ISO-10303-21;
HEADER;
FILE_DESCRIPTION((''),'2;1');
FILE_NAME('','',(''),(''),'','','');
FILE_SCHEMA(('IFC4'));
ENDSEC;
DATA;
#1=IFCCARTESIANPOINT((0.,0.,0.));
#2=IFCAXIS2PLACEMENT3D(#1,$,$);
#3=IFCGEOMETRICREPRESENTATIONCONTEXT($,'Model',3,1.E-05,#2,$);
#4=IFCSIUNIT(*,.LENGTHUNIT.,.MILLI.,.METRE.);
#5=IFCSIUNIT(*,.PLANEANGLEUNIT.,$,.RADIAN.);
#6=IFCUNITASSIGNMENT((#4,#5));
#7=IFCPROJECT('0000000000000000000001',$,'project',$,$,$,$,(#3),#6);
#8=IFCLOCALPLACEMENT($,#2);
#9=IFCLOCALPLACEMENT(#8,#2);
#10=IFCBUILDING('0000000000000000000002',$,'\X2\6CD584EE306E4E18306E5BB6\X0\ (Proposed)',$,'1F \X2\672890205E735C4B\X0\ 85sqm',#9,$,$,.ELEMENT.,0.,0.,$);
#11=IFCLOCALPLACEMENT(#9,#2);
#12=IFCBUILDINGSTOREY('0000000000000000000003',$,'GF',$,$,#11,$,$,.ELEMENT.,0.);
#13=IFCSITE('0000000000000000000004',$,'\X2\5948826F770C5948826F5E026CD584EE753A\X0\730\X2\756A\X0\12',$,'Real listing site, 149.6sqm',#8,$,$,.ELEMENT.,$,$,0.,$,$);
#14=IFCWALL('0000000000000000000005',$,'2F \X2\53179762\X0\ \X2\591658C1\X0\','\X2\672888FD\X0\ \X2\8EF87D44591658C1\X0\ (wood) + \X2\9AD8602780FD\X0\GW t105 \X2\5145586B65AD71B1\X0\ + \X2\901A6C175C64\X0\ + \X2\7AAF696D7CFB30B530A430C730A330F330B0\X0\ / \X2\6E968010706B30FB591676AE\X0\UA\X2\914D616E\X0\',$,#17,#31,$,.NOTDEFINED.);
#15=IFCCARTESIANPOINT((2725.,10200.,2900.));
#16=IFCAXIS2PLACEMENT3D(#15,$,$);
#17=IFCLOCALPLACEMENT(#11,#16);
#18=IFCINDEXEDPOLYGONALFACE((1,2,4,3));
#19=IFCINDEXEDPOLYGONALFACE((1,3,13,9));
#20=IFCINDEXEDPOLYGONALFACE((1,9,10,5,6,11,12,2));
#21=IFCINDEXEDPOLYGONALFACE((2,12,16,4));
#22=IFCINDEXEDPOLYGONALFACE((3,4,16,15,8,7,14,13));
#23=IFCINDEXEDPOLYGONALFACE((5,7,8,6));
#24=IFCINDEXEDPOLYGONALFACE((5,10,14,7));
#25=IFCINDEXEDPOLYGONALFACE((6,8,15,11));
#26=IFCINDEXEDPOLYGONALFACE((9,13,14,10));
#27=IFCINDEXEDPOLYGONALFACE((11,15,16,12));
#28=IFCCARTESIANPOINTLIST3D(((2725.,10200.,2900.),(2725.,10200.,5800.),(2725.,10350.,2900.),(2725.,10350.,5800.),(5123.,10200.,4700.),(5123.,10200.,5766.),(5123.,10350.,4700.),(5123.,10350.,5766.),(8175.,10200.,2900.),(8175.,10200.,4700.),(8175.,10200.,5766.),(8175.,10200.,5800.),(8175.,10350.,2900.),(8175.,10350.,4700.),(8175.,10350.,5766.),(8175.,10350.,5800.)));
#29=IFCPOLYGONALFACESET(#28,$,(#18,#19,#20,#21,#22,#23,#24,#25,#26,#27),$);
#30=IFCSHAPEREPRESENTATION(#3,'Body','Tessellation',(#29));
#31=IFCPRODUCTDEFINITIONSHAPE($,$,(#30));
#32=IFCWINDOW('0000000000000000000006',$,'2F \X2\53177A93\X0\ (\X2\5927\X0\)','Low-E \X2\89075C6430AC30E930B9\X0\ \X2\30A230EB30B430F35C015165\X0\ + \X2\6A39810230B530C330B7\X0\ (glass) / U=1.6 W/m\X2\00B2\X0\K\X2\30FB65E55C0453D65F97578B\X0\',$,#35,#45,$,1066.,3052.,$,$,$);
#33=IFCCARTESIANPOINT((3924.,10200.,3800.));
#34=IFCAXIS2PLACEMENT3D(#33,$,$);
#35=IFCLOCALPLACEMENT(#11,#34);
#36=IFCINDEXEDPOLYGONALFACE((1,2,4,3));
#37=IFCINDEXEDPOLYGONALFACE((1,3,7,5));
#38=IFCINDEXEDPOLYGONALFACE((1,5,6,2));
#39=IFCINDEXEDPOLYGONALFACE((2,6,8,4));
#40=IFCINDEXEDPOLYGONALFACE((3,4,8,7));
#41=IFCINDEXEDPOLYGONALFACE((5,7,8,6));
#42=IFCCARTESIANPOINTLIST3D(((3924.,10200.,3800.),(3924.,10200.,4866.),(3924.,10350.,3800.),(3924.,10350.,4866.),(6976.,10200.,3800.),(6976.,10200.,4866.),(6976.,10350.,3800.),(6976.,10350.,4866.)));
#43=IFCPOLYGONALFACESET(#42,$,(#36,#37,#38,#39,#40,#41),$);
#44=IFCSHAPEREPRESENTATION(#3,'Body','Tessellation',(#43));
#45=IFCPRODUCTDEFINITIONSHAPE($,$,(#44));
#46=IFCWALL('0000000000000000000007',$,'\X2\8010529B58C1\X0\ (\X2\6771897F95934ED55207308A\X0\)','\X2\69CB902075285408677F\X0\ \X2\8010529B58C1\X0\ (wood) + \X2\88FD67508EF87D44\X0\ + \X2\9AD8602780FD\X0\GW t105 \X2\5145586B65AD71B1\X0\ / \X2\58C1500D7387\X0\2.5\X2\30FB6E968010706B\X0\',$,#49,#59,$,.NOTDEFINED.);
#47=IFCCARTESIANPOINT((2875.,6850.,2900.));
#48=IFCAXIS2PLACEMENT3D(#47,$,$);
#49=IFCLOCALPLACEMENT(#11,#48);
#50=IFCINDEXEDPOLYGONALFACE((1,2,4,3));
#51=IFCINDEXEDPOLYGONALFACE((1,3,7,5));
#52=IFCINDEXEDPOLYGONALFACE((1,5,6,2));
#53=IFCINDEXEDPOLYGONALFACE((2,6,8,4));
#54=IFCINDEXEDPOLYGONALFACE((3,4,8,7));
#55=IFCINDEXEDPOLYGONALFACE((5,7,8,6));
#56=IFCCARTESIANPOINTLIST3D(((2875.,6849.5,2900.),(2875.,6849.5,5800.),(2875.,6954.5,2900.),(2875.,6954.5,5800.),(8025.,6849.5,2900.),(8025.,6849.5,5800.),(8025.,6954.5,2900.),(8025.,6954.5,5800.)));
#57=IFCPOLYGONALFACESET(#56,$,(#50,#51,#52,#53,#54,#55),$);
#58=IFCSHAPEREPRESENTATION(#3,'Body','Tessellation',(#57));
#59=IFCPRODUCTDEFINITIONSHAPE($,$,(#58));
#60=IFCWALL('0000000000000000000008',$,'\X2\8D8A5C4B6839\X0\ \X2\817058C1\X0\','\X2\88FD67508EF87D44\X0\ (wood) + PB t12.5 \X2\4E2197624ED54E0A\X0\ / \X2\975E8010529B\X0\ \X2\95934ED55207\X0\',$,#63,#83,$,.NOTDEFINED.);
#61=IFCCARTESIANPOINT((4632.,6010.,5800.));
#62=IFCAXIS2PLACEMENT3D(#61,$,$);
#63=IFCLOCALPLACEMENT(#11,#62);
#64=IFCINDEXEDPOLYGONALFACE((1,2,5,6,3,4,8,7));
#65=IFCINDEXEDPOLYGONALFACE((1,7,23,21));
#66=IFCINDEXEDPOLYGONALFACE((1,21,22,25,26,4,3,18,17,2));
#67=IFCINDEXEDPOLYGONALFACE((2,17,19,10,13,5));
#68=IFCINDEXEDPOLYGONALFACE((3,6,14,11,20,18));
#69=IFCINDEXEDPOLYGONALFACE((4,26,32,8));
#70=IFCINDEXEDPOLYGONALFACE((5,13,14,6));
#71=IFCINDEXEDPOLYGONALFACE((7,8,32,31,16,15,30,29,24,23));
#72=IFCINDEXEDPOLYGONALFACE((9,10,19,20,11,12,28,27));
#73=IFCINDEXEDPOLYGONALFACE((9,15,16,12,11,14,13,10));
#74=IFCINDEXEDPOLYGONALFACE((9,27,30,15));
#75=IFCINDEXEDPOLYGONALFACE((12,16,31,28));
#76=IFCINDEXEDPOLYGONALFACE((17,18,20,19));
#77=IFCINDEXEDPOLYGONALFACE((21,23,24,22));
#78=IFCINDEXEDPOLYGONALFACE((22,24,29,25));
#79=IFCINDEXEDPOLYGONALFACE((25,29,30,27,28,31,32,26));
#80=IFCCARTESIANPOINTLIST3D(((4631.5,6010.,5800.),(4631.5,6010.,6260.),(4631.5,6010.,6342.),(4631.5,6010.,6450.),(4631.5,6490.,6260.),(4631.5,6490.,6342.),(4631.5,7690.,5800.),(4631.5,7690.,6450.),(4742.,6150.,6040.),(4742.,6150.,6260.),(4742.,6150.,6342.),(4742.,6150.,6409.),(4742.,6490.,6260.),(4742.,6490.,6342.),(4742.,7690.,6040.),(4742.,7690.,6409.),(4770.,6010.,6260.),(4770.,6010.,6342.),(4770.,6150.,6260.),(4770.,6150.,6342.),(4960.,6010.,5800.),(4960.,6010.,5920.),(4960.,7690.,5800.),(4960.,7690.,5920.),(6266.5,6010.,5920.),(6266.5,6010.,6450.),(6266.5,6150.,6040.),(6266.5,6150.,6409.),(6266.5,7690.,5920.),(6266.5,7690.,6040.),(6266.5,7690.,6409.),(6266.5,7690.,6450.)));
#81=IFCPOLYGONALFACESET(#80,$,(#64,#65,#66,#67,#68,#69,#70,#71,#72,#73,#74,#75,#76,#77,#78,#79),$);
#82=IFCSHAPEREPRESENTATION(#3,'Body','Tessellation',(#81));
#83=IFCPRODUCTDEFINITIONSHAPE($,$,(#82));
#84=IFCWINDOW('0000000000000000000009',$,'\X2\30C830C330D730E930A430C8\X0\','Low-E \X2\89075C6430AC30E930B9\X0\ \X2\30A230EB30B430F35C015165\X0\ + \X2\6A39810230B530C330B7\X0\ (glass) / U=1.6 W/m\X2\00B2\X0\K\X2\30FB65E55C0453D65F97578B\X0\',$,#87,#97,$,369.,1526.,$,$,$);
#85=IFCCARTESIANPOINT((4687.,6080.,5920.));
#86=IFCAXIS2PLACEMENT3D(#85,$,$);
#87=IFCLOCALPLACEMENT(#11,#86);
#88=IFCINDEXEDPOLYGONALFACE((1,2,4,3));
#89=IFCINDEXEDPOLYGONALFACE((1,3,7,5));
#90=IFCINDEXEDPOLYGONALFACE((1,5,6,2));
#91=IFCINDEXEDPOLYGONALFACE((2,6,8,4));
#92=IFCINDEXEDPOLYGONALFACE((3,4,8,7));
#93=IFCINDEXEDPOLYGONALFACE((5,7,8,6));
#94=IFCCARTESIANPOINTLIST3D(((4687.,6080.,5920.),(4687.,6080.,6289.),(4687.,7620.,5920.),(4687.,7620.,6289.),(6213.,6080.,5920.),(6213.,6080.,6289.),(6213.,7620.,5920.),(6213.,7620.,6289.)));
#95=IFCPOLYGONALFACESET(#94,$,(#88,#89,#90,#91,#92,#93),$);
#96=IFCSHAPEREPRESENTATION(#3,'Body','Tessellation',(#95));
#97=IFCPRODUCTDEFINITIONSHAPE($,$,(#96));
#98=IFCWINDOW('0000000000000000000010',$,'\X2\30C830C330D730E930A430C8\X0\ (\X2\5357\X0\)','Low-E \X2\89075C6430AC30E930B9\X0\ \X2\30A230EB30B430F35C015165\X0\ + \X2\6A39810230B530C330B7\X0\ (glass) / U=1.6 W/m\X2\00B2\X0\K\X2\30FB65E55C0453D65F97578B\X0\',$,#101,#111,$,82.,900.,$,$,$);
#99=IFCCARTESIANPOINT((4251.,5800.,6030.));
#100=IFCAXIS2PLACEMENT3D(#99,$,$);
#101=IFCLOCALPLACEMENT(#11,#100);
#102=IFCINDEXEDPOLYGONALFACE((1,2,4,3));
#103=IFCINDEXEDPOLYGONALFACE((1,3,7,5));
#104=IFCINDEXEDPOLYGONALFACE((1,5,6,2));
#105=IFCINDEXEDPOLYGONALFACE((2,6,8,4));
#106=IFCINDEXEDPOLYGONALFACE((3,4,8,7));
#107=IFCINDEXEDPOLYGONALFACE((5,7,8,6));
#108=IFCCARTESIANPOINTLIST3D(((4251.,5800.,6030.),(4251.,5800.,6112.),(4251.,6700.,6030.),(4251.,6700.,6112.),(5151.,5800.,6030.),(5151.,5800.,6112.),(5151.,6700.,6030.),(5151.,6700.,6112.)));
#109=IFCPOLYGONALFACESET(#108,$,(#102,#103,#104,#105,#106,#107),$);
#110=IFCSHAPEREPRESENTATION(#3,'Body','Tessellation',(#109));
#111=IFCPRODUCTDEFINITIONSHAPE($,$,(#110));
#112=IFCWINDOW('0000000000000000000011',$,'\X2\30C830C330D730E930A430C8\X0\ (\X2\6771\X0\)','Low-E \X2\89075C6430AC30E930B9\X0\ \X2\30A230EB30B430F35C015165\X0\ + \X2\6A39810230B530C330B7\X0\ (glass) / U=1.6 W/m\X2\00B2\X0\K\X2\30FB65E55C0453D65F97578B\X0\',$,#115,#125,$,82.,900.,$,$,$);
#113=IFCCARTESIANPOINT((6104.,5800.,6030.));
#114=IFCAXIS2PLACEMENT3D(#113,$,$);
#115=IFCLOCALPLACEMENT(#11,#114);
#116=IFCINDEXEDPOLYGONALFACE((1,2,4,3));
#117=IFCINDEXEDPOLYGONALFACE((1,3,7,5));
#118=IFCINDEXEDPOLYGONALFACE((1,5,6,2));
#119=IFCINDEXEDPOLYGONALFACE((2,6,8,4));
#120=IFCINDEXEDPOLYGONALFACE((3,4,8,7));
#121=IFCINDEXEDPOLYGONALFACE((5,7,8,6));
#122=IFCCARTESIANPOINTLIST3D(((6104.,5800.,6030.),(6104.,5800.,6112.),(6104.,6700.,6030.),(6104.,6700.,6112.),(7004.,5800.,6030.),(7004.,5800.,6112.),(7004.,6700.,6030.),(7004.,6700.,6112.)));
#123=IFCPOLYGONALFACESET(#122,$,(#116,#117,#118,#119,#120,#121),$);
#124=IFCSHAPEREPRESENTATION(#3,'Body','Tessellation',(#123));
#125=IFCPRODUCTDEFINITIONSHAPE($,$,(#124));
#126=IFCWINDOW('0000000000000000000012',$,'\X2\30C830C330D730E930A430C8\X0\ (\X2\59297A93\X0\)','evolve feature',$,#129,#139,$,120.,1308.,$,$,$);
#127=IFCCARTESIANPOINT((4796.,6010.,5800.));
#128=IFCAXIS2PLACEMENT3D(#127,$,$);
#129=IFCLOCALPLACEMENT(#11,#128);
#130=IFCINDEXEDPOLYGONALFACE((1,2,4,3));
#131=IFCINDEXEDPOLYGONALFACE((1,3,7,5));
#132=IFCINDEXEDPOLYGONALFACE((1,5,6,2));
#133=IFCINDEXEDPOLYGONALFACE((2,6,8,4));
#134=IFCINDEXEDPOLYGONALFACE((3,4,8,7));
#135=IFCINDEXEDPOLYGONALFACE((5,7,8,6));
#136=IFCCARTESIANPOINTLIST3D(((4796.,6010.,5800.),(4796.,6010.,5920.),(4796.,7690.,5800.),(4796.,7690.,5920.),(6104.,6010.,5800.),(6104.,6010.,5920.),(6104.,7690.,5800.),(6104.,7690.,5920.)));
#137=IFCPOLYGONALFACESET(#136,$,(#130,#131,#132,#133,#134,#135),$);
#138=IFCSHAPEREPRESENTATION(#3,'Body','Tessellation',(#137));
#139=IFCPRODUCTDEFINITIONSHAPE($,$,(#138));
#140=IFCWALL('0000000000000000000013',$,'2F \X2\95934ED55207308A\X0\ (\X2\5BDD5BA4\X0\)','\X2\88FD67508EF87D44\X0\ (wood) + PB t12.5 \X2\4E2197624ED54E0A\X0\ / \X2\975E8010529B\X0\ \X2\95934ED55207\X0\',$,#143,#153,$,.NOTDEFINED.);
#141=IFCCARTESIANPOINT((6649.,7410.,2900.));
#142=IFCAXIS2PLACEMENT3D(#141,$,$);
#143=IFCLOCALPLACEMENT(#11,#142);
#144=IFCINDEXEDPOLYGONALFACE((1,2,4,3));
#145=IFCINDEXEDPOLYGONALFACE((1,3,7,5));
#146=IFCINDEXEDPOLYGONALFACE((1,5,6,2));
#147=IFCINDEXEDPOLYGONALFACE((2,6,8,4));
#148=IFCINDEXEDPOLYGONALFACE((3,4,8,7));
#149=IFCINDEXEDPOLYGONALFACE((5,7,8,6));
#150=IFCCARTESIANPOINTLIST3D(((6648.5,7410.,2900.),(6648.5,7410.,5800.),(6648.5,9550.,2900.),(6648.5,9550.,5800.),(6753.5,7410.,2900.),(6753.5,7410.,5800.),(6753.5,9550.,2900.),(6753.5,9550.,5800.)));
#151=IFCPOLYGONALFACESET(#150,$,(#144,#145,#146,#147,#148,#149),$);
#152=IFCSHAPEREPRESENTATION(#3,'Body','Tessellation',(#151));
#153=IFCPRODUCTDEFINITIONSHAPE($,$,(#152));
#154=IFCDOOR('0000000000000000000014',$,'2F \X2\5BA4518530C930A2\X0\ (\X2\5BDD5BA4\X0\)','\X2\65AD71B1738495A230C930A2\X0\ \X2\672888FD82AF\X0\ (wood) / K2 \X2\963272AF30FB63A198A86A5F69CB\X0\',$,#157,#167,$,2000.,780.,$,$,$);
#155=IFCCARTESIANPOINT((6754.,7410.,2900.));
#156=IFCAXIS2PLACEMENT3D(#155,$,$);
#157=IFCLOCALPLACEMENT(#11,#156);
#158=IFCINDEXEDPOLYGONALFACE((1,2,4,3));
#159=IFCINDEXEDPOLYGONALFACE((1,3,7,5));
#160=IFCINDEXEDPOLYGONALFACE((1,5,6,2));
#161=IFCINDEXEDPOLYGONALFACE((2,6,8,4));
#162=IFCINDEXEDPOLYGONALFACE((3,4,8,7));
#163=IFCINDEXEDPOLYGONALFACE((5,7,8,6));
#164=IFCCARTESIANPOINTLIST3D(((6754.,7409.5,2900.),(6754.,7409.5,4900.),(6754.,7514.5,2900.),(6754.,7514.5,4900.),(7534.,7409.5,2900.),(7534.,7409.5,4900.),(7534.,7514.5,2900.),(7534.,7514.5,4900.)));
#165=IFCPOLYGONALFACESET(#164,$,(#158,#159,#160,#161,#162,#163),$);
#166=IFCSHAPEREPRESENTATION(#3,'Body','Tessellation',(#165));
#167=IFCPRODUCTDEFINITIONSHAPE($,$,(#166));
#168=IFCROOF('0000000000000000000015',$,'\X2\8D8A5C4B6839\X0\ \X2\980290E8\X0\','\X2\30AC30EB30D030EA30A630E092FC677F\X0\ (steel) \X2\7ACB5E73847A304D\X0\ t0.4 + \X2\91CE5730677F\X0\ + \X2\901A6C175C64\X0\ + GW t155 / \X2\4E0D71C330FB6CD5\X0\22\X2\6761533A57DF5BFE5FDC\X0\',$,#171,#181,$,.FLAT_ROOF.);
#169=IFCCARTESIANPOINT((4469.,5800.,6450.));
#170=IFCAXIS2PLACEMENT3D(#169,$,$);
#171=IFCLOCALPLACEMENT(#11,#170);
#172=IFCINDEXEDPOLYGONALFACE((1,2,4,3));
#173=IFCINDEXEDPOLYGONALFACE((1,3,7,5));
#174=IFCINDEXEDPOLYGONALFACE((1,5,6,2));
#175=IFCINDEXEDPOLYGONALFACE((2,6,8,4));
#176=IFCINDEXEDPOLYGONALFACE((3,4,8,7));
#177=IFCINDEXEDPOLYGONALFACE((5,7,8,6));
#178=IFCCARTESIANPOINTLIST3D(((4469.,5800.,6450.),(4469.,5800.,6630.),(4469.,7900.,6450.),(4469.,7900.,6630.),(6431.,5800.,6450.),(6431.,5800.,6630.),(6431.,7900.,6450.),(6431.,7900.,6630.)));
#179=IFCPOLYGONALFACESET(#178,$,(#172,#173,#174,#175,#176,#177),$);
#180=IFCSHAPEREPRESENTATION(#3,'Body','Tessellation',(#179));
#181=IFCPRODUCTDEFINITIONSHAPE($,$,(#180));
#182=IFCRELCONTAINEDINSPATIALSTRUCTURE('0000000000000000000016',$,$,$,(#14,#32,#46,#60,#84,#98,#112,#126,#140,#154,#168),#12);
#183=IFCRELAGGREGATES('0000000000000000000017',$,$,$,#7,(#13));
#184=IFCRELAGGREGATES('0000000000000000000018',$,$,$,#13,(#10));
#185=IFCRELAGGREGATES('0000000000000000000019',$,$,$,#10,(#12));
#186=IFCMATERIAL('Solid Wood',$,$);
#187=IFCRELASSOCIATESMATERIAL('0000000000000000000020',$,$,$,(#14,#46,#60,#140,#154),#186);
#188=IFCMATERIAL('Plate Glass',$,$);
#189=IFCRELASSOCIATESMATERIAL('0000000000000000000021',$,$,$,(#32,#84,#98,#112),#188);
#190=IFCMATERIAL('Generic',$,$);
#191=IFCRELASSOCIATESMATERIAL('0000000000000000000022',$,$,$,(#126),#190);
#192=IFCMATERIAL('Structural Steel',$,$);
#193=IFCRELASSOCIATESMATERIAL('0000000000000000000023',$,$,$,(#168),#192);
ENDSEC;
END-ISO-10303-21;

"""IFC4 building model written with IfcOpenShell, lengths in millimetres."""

from ifc_helpers import new_model, si_unit, frame, frame_2d, origin, place, context, project, spatial, rectangle, extrude, material, element, fill, save


model = new_model("IFC4")

# Units and contexts
model_context = context("Model", 3, precision=1e-05, world=origin())
ifc_project = project(units=[si_unit("LENGTHUNIT", "METRE", prefix="MILLI"), si_unit("PLANEANGLEUNIT", "RADIAN")], contexts=[model_context])

# Site, building, storey
site_placement = place(None, origin())
site = spatial("IfcSite", under=ifc_project, at=site_placement, Name="奈良県奈良市法蓮町730番12", ObjectType="Real listing site, 149.6sqm", CompositionType="ELEMENT", RefElevation=0.0)
building_placement = place(site_placement, origin())
building = spatial("IfcBuilding", under=site, at=building_placement, Name="法蓮の丘の家 (Proposed)", ObjectType="1F 木造平屋 85sqm", CompositionType="ELEMENT", ElevationOfRefHeight=0.0, ElevationOfTerrain=0.0)
storey_placement = place(building_placement, origin())
storey = spatial("IfcBuildingStorey", under=building, at=storey_placement, Name="GF", CompositionType="ELEMENT", Elevation=0.0)

# Wall, opening, window
ifc_material_1 = material(Name="Solid Wood")
wall_1_placement = place(storey_placement, frame((2725.0, 10200.0, 2900.0)))
wall_1 = element("IfcWall", 1, at=wall_1_placement, inside=storey, material=ifc_material_1, Name="2F 北面 外壁", Description="木製 軸組外壁 (wood) + 高性能GW t105 充填断熱 + 通気層 + 窯業系サイディング / 準耐火・外皮UA配慮", PredefinedType="NOTDEFINED", context=model_context, shape_type="SweptSolid", body=[
    extrude(rectangle(XDim=5450.0, YDim=150.0, at=frame_2d((2725.0, 75.0))), frame((2725.0, 10200.0, 2900.0)), (0.0, 0.0, 1.0), 2900.0),
])
opening_1_placement = place(storey_placement, frame((3924.0, 10200.0, 3800.0)))
opening_1 = element("IfcOpeningElement", 2, at=opening_1_placement, cuts=wall_1, PredefinedType="NOTDEFINED", context=model_context, shape_type="SweptSolid", body=[
    extrude(rectangle(XDim=3052.0, YDim=150.0, at=frame_2d((1526.0, 75.0))), frame((3924.0, 10200.0, 3800.0)), (0.0, 0.0, 1.0), 1066.0),
])
ifc_material_2 = material(Name="Plate Glass")
window_1_placement = place(storey_placement, frame((3924.0, 10200.0, 3800.0)))
window_1 = element("IfcWindow", 3, at=window_1_placement, inside=storey, material=ifc_material_2, Name="2F 北窓 (大)", Description="Low-E 複層ガラス アルゴン封入 + 樹脂サッシ (glass) / U=1.6 W/m²K・日射取得型", OverallHeight=1066.0, OverallWidth=3052.0, context=model_context, shape_type="SweptSolid", body=[
    extrude(rectangle(XDim=3052.0, YDim=150.0, at=frame_2d((1526.0, 75.0))), frame((3924.0, 10200.0, 3800.0)), (0.0, 0.0, 1.0), 1066.0),
])
fill(opening_1, window_1)

# Wall
wall_2_placement = place(storey_placement, frame((2875.0, 6850.0, 2900.0)))
element("IfcWall", 4, at=wall_2_placement, inside=storey, material=ifc_material_1, Name="耐力壁 (東西間仕切り)", Description="構造用合板 耐力壁 (wood) + 製材軸組 + 高性能GW t105 充填断熱 / 壁倍率2.5・準耐火", PredefinedType="NOTDEFINED", context=model_context, shape_type="SweptSolid", body=[
    extrude(rectangle(XDim=5150.0, YDim=105.0, at=frame_2d((2575.0, 52.0))), frame((2875.0, 6850.0, 2900.0)), (0.0, 0.0, 1.0), 2900.0),
])

# Wall, openings, windows
wall_3_placement = place(storey_placement, frame((4632.0, 6010.0, 5800.0)))
wall_3 = element("IfcWall", 5, at=wall_3_placement, inside=storey, material=ifc_material_1, Name="越屋根 腰壁", Description="製材軸組 (wood) + PB t12.5 両面仕上 / 非耐力 間仕切", PredefinedType="NOTDEFINED", context=model_context, shape_type="SweptSolid", body=[
    extrude(rectangle(XDim=1635.0, YDim=1680.0, at=frame_2d((817.0, 840.0))), frame((4632.0, 6010.0, 5800.0)), (0.0, 0.0, 1.0), 650.0),
])
opening_2_placement = place(storey_placement, frame((4687.0, 6080.0, 5920.0)))
opening_2 = element("IfcOpeningElement", 6, at=opening_2_placement, cuts=wall_3, PredefinedType="NOTDEFINED", context=model_context, shape_type="SweptSolid", body=[
    extrude(rectangle(XDim=1526.0, YDim=1540.0, at=frame_2d((763.0, 770.0))), frame((4687.0, 6080.0, 5920.0)), (0.0, 0.0, 1.0), 369.0),
])
opening_3_placement = place(storey_placement, frame((4251.0, 5800.0, 6030.0)))
opening_3 = element("IfcOpeningElement", 7, at=opening_3_placement, cuts=wall_3, PredefinedType="NOTDEFINED", context=model_context, shape_type="SweptSolid", body=[
    extrude(rectangle(XDim=900.0, YDim=900.0, at=frame_2d((450.0, 450.0))), frame((4251.0, 5800.0, 6030.0)), (0.0, 0.0, 1.0), 82.0),
])
opening_4_placement = place(storey_placement, frame((6104.0, 5800.0, 6030.0)))
opening_4 = element("IfcOpeningElement", 8, at=opening_4_placement, cuts=wall_3, PredefinedType="NOTDEFINED", context=model_context, shape_type="SweptSolid", body=[
    extrude(rectangle(XDim=900.0, YDim=900.0, at=frame_2d((450.0, 450.0))), frame((6104.0, 5800.0, 6030.0)), (0.0, 0.0, 1.0), 82.0),
])
opening_5_placement = place(storey_placement, frame((4796.0, 6010.0, 5800.0)))
opening_5 = element("IfcOpeningElement", 9, at=opening_5_placement, cuts=wall_3, PredefinedType="NOTDEFINED", context=model_context, shape_type="SweptSolid", body=[
    extrude(rectangle(XDim=1308.0, YDim=1680.0, at=frame_2d((654.0, 840.0))), frame((4796.0, 6010.0, 5800.0)), (0.0, 0.0, 1.0), 120.0),
])
window_2_placement = place(storey_placement, frame((4687.0, 6080.0, 5920.0)))
window_2 = element("IfcWindow", 10, at=window_2_placement, inside=storey, material=ifc_material_2, Name="トップライト", Description="Low-E 複層ガラス アルゴン封入 + 樹脂サッシ (glass) / U=1.6 W/m²K・日射取得型", OverallHeight=369.0, OverallWidth=1526.0, context=model_context, shape_type="SweptSolid", body=[
    extrude(rectangle(XDim=1526.0, YDim=1540.0, at=frame_2d((763.0, 770.0))), frame((4687.0, 6080.0, 5920.0)), (0.0, 0.0, 1.0), 369.0),
])
fill(opening_2, window_2)
window_3_placement = place(storey_placement, frame((4251.0, 5800.0, 6030.0)))
window_3 = element("IfcWindow", 11, at=window_3_placement, inside=storey, material=ifc_material_2, Name="トップライト (南)", Description="Low-E 複層ガラス アルゴン封入 + 樹脂サッシ (glass) / U=1.6 W/m²K・日射取得型", OverallHeight=82.0, OverallWidth=900.0, context=model_context, shape_type="SweptSolid", body=[
    extrude(rectangle(XDim=900.0, YDim=900.0, at=frame_2d((450.0, 450.0))), frame((4251.0, 5800.0, 6030.0)), (0.0, 0.0, 1.0), 82.0),
])
fill(opening_3, window_3)
window_4_placement = place(storey_placement, frame((6104.0, 5800.0, 6030.0)))
window_4 = element("IfcWindow", 12, at=window_4_placement, inside=storey, material=ifc_material_2, Name="トップライト (東)", Description="Low-E 複層ガラス アルゴン封入 + 樹脂サッシ (glass) / U=1.6 W/m²K・日射取得型", OverallHeight=82.0, OverallWidth=900.0, context=model_context, shape_type="SweptSolid", body=[
    extrude(rectangle(XDim=900.0, YDim=900.0, at=frame_2d((450.0, 450.0))), frame((6104.0, 5800.0, 6030.0)), (0.0, 0.0, 1.0), 82.0),
])
fill(opening_4, window_4)
ifc_material_3 = material(Name="Generic")
window_5_placement = place(storey_placement, frame((4796.0, 6010.0, 5800.0)))
window_5 = element("IfcWindow", 13, at=window_5_placement, inside=storey, material=ifc_material_3, Name="トップライト (天窓)", Description="evolve feature", OverallHeight=120.0, OverallWidth=1308.0, context=model_context, shape_type="SweptSolid", body=[
    extrude(rectangle(XDim=1308.0, YDim=1680.0, at=frame_2d((654.0, 840.0))), frame((4796.0, 6010.0, 5800.0)), (0.0, 0.0, 1.0), 120.0),
])
fill(opening_5, window_5)

# Wall
wall_4_placement = place(storey_placement, frame((6649.0, 7410.0, 2900.0)))
element("IfcWall", 14, at=wall_4_placement, inside=storey, material=ifc_material_1, Name="2F 間仕切り (寝室)", Description="製材軸組 (wood) + PB t12.5 両面仕上 / 非耐力 間仕切", PredefinedType="NOTDEFINED", context=model_context, shape_type="SweptSolid", body=[
    extrude(rectangle(XDim=105.0, YDim=2140.0, at=frame_2d((52.0, 1070.0))), frame((6649.0, 7410.0, 2900.0)), (0.0, 0.0, 1.0), 2900.0),
])

# Door
door_placement = place(storey_placement, frame((6754.0, 7410.0, 2900.0)))
element("IfcDoor", 15, at=door_placement, inside=storey, material=ifc_material_1, Name="2F 室内ドア (寝室)", Description="断熱玄関ドア 木製芯 (wood) / K2 防犯・採風機構", OverallHeight=2000.0, OverallWidth=780.0, context=model_context, shape_type="SweptSolid", body=[
    extrude(rectangle(XDim=780.0, YDim=105.0, at=frame_2d((390.0, 52.0))), frame((6754.0, 7410.0, 2900.0)), (0.0, 0.0, 1.0), 2000.0),
])

# Roof
ifc_material_4 = material(Name="Structural Steel")
roof_placement = place(storey_placement, frame((4469.0, 5800.0, 6450.0)))
element("IfcRoof", 16, at=roof_placement, inside=storey, material=ifc_material_4, Name="越屋根 頂部", Description="ガルバリウム鋼板 (steel) 立平葺き t0.4 + 野地板 + 通気層 + GW t155 / 不燃・法22条区域対応", PredefinedType="FLAT_ROOF", context=model_context, shape_type="SweptSolid", body=[
    extrude(rectangle(XDim=1962.0, YDim=2100.0, at=frame_2d((981.0, 1050.0))), frame((4469.0, 5800.0, 6450.0)), (0.0, 0.0, 1.0), 180.0),
])

save(model, "model.ifc")
